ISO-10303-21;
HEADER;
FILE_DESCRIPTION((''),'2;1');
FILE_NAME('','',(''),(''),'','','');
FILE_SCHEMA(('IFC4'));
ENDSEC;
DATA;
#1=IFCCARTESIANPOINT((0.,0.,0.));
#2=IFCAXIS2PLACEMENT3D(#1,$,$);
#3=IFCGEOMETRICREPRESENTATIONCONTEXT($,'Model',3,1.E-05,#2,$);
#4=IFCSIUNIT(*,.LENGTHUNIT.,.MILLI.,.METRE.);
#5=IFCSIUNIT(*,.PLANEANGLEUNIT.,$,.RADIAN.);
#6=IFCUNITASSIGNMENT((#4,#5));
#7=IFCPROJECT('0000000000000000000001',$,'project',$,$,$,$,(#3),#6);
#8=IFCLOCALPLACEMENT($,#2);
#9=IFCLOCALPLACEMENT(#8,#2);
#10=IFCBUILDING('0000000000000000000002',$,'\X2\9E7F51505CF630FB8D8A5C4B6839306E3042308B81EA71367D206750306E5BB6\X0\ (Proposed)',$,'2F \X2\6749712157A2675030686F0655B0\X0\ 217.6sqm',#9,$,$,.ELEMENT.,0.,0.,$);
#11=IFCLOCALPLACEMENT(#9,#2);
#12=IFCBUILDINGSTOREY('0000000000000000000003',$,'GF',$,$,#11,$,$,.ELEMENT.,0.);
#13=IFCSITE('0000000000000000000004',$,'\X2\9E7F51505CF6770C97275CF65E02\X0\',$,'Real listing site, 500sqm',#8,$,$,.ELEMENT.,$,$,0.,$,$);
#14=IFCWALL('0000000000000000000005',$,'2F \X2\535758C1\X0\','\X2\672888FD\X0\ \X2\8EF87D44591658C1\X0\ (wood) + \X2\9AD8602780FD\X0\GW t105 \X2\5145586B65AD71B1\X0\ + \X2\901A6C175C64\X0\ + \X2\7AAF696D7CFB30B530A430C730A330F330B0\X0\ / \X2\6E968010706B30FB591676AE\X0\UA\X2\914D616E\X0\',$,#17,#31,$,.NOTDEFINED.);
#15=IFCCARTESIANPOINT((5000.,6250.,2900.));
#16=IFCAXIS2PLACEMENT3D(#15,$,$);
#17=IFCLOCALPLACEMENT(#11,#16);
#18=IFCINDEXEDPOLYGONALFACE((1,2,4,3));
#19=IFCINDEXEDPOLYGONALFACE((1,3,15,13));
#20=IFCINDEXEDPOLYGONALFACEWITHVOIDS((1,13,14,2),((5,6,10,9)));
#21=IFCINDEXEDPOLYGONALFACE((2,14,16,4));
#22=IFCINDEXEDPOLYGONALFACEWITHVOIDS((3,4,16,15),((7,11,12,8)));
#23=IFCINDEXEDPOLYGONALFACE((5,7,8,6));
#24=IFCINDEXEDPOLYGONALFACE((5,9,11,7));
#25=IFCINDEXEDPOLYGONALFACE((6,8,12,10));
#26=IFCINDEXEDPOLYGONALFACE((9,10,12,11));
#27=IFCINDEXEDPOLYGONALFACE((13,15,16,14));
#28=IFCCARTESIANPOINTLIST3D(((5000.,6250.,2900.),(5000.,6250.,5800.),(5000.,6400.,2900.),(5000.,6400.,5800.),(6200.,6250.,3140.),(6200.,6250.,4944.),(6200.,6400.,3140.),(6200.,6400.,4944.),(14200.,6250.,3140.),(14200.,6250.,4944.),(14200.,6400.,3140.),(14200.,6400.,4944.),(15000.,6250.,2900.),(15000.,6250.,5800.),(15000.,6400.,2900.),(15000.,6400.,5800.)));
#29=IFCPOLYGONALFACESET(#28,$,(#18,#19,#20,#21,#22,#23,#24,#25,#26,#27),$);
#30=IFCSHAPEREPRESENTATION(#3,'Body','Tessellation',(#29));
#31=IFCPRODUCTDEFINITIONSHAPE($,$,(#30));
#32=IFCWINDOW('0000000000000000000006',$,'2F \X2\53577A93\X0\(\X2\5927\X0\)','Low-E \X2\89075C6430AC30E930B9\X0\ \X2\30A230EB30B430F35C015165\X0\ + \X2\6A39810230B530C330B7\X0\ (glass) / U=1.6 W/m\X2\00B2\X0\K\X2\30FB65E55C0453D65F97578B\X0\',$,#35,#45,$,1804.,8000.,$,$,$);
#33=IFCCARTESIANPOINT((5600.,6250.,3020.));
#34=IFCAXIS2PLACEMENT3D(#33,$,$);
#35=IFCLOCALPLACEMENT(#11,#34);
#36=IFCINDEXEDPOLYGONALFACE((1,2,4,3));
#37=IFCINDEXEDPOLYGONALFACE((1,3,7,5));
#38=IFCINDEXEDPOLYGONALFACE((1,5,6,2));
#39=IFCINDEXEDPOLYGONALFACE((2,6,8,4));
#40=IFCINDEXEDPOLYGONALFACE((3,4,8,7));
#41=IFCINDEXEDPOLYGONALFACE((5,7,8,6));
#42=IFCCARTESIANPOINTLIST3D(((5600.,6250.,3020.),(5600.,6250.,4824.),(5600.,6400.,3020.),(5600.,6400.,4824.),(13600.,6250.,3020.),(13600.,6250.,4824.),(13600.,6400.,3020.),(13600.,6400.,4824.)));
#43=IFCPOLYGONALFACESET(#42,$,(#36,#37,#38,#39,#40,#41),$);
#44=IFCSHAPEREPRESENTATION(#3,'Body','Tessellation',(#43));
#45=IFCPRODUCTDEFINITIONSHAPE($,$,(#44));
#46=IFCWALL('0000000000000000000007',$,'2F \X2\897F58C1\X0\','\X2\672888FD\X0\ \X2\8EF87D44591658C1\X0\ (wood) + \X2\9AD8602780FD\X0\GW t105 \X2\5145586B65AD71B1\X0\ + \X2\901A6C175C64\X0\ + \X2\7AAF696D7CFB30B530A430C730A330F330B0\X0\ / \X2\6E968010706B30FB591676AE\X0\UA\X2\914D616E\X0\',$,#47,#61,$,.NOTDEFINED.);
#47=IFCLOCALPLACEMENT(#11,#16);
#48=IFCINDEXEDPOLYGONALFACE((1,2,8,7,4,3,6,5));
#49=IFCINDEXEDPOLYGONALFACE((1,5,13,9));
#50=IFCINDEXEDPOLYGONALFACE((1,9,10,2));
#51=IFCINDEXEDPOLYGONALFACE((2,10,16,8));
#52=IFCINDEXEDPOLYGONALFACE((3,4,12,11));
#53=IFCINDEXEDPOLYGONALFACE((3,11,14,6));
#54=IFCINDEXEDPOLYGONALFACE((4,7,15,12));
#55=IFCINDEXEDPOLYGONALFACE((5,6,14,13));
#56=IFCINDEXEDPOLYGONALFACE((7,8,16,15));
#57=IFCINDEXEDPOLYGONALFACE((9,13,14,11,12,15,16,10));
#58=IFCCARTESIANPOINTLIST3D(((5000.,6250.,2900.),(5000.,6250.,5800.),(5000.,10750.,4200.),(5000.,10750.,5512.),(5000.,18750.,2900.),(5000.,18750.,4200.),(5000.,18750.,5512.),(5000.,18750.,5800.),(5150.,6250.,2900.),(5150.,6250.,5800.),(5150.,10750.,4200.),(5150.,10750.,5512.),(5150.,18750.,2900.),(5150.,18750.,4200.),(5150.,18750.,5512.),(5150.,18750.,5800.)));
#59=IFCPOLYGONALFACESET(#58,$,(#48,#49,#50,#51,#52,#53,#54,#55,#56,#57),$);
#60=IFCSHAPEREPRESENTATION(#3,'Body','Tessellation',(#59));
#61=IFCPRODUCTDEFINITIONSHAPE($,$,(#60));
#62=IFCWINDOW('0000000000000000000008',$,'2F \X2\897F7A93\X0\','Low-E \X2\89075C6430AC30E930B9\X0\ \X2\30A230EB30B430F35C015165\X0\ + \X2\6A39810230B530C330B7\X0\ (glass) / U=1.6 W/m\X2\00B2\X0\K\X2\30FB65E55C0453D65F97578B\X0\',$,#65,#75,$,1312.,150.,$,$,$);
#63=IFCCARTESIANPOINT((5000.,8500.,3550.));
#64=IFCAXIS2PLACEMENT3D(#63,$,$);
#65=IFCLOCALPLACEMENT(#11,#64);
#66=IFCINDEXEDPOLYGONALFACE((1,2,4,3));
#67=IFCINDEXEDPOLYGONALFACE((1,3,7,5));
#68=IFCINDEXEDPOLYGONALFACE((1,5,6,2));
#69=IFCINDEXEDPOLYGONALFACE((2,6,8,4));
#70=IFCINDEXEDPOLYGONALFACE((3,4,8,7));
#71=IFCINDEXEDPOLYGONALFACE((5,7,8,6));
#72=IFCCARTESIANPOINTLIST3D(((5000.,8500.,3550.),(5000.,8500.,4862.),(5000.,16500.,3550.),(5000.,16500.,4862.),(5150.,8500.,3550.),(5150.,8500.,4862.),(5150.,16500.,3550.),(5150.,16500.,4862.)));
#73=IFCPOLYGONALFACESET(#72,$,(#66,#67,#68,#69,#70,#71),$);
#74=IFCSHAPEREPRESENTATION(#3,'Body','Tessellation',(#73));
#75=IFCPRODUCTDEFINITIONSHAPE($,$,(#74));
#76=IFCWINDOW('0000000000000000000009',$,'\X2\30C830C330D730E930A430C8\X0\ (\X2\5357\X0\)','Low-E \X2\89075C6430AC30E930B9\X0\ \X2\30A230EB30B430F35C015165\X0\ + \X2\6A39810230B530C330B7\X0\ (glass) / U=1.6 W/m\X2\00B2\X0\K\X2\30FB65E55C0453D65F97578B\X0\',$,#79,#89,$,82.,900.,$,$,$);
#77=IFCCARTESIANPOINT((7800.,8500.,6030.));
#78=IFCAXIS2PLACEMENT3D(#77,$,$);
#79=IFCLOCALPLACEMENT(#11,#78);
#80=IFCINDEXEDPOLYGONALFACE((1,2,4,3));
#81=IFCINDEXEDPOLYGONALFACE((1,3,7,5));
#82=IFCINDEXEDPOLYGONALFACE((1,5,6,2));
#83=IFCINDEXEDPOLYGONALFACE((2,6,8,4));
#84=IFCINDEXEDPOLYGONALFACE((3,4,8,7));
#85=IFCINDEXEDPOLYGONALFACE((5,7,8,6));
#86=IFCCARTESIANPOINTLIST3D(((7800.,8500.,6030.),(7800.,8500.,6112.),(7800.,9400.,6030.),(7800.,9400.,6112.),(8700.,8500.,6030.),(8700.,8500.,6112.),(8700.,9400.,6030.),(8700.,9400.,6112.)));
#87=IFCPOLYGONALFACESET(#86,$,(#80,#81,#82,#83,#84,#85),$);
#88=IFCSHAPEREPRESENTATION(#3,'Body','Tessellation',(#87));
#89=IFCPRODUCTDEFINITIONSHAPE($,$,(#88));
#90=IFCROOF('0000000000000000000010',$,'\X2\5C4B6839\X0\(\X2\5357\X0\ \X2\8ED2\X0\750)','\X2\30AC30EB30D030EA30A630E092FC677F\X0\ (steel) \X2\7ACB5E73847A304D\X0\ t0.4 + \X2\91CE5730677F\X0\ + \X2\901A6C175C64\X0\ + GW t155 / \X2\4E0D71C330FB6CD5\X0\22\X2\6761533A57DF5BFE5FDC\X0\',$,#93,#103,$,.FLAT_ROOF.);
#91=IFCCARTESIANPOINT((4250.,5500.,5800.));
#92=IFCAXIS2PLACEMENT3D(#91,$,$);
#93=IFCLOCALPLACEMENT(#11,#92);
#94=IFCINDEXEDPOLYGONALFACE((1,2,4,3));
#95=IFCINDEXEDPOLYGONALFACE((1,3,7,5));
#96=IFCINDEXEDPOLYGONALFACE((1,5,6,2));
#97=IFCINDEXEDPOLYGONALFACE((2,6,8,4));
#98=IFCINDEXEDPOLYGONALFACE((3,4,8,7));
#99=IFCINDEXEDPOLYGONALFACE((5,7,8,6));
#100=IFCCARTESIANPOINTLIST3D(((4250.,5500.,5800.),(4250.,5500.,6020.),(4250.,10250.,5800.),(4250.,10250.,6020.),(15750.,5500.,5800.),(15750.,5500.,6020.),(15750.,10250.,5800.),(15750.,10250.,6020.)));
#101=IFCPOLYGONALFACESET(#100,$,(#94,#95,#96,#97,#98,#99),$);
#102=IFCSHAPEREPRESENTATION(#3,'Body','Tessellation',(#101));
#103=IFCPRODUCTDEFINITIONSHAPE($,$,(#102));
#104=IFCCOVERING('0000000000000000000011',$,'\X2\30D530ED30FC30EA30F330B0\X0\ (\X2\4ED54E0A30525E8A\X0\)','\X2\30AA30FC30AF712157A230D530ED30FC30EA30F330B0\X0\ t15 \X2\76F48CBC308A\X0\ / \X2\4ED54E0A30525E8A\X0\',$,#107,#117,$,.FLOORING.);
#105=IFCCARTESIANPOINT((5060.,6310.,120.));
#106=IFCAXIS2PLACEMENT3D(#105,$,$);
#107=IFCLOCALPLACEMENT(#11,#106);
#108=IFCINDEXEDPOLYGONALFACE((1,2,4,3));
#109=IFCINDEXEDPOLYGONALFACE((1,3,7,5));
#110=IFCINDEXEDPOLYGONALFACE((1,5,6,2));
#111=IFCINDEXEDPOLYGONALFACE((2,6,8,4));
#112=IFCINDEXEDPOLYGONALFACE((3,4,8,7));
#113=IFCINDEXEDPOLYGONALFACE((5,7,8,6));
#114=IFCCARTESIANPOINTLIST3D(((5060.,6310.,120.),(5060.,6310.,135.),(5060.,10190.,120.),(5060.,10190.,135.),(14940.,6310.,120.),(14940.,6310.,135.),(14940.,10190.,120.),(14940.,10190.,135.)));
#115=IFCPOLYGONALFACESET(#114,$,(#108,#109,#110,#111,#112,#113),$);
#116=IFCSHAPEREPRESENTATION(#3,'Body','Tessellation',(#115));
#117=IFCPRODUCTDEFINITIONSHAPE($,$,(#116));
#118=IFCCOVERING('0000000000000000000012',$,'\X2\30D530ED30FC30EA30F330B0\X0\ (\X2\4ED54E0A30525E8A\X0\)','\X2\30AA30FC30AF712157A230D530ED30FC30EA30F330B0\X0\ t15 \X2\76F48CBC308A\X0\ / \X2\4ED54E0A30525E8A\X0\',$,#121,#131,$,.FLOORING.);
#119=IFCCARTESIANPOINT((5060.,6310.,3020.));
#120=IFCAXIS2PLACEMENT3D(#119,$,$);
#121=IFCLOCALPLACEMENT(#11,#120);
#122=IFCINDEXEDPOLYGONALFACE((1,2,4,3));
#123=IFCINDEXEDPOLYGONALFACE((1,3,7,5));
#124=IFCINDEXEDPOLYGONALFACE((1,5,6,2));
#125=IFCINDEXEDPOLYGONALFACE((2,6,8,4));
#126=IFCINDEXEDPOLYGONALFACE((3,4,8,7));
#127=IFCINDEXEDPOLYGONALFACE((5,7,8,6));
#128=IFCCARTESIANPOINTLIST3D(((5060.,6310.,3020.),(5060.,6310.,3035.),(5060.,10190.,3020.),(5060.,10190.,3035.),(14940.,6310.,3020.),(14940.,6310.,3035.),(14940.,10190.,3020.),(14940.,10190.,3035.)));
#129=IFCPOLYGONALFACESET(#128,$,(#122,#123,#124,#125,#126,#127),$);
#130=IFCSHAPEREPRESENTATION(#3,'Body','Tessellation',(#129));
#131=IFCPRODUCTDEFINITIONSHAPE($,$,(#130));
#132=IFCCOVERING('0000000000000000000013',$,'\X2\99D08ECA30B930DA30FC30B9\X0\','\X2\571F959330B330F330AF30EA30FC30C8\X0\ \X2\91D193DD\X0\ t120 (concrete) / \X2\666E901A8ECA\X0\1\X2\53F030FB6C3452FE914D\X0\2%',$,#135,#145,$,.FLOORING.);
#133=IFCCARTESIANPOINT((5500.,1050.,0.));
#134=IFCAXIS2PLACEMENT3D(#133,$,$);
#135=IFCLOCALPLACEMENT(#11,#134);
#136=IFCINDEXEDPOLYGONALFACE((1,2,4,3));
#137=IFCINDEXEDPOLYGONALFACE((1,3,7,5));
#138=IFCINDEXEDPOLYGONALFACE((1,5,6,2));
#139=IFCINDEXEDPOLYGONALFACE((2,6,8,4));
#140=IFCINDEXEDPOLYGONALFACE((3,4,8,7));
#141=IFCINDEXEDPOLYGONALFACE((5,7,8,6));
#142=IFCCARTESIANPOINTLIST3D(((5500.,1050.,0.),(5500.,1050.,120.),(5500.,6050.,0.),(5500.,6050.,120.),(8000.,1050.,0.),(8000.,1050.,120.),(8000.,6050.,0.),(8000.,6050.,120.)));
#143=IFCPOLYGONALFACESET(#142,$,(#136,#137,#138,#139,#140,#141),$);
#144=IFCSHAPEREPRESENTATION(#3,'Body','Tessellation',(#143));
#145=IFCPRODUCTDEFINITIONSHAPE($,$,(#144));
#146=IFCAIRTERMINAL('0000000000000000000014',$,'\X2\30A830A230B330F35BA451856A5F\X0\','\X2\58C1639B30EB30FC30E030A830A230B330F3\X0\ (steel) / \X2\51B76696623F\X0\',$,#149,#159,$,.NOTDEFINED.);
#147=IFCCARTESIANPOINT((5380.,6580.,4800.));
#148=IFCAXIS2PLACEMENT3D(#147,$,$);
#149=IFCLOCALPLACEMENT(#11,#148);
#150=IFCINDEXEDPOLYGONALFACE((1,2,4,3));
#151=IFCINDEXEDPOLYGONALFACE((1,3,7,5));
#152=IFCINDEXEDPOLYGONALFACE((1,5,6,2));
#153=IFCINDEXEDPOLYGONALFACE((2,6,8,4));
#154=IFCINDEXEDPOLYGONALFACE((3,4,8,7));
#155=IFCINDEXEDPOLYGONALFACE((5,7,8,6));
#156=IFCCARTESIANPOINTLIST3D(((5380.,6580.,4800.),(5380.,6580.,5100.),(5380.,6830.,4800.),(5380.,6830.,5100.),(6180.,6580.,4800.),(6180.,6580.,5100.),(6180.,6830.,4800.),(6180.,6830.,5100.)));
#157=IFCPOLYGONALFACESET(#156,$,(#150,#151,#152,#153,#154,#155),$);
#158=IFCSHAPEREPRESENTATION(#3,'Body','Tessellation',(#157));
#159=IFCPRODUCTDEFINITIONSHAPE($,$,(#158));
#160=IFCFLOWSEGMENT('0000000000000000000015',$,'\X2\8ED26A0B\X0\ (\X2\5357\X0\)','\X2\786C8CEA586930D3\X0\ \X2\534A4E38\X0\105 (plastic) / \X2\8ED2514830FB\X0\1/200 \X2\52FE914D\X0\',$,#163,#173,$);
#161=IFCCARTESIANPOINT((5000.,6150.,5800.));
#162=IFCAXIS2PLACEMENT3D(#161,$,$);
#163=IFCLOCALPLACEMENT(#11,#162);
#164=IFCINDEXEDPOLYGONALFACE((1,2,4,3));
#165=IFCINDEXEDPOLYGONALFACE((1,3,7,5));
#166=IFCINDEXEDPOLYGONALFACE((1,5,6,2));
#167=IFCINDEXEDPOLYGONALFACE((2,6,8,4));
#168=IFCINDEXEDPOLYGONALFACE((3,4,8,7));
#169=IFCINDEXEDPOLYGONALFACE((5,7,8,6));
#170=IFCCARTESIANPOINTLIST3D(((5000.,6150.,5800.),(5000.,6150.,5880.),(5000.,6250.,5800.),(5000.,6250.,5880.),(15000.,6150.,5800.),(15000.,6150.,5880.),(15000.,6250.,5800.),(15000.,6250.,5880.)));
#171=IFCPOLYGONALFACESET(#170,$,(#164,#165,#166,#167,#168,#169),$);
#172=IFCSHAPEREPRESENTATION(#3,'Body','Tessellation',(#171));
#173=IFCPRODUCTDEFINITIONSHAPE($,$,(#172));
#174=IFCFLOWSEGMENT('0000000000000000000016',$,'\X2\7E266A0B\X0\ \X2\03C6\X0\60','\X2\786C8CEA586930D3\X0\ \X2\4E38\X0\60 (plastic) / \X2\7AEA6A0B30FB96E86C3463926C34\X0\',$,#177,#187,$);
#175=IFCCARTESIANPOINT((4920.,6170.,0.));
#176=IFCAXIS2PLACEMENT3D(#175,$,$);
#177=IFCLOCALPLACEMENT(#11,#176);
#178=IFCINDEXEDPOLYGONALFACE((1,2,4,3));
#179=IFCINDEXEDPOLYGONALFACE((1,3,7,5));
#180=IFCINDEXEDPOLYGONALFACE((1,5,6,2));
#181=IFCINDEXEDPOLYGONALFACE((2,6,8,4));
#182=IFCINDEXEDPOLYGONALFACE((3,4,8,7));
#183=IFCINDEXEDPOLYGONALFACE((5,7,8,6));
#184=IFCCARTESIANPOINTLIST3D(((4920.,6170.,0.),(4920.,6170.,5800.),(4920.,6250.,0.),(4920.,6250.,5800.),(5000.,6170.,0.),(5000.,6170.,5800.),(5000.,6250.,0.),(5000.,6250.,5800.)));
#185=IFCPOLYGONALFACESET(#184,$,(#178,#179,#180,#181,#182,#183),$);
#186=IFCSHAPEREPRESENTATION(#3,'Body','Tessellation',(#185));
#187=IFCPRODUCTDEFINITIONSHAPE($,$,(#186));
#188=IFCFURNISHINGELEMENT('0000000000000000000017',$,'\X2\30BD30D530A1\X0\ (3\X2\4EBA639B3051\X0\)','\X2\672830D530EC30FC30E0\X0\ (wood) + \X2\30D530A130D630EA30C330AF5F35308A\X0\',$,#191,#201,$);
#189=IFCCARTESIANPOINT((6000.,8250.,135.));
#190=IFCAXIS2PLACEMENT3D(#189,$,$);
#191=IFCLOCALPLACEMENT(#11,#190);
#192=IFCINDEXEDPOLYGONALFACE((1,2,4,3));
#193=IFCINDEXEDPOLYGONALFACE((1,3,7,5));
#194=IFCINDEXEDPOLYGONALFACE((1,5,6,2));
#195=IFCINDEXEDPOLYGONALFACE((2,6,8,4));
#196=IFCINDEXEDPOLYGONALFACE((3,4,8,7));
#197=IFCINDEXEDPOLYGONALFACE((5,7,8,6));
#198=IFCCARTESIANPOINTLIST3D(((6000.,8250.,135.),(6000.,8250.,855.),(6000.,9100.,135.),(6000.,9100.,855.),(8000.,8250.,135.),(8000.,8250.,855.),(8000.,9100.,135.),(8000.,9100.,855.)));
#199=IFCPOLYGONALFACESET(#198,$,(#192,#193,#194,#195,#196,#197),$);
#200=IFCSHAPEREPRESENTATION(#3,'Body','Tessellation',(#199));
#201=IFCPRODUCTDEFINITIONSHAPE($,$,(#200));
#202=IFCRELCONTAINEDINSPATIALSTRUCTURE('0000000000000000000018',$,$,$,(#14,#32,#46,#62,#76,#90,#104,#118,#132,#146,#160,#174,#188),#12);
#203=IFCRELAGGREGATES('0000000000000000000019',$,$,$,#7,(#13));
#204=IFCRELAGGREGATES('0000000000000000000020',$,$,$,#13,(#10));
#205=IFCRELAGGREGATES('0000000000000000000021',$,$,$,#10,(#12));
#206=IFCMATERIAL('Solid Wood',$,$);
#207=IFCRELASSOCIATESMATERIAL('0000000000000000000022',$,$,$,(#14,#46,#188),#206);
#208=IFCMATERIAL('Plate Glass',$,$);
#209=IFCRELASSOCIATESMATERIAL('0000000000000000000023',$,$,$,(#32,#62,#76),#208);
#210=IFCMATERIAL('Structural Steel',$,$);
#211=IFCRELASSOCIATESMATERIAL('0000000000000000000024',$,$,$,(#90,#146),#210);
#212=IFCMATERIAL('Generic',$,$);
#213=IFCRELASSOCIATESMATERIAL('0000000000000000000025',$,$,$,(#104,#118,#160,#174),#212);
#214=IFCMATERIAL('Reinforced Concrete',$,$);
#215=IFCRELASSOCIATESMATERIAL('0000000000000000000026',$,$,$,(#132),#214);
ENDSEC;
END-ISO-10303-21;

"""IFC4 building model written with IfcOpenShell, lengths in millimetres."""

from ifc_helpers import new_model, si_unit, frame, frame_2d, origin, place, context, project, spatial, rectangle, extrude, material, element, fill, save


model = new_model("IFC4")

# Units and contexts
model_context = context("Model", 3, precision=1e-05, world=origin())
ifc_project = project(units=[si_unit("LENGTHUNIT", "METRE", prefix="MILLI"), si_unit("PLANEANGLEUNIT", "RADIAN")], contexts=[model_context])

# Site, building, storey
site_placement = place(None, origin())
site = spatial("IfcSite", under=ifc_project, at=site_placement, Name="鹿児島県霧島市", ObjectType="Real listing site, 500sqm", CompositionType="ELEMENT", RefElevation=0.0)
building_placement = place(site_placement, origin())
building = spatial("IfcBuilding", under=site, at=building_placement, Name="鹿児島・越屋根のある自然素材の家 (Proposed)", ObjectType="2F 杉無垢材と漆喰 217.6sqm", CompositionType="ELEMENT", ElevationOfRefHeight=0.0, ElevationOfTerrain=0.0)
storey_placement = place(building_placement, origin())
storey = spatial("IfcBuildingStorey", under=building, at=storey_placement, Name="GF", CompositionType="ELEMENT", Elevation=0.0)

# Shared definitions
ifc_material_1 = material(Name="Solid Wood")

# Shared definitions
ifc_material_2 = material(Name="Reinforced Concrete")

# Shared definitions
ifc_material_3 = material(Name="Plate Glass")

# Walls, openings, windows
wall_1_placement = place(storey_placement, frame((5000.0, 6250.0, 2900.0)))
wall_1 = element("IfcWall", 1, at=wall_1_placement, inside=storey, material=ifc_material_1, Name="2F 南壁", Description="木製 軸組外壁 (wood) + 高性能GW t105 充填断熱 + 通気層 + 窯業系サイディング / 準耐火・外皮UA配慮", PredefinedType="NOTDEFINED", context=model_context, shape_type="SweptSolid", body=[
    extrude(rectangle(XDim=10000.0, YDim=150.0, at=frame_2d((5000.0, 75.0))), frame((5000.0, 6250.0, 2900.0)), (0.0, 0.0, 1.0), 2900.0),
])
opening_1_placement = place(storey_placement, frame((5600.0, 6250.0, 3020.0)))
opening_1 = element("IfcOpeningElement", 2, at=opening_1_placement, cuts=wall_1, PredefinedType="NOTDEFINED", context=model_context, shape_type="SweptSolid", body=[
    extrude(rectangle(XDim=8000.0, YDim=150.0, at=frame_2d((4000.0, 75.0))), frame((5600.0, 6250.0, 3020.0)), (0.0, 0.0, 1.0), 1804.0),
])
window_1_placement = place(storey_placement, frame((5600.0, 6250.0, 3020.0)))
window_1 = element("IfcWindow", 3, at=window_1_placement, inside=storey, material=ifc_material_3, Name="2F 南窓(大)", Description="Low-E 複層ガラス アルゴン封入 + 樹脂サッシ (glass) / U=1.6 W/m²K・日射取得型", OverallHeight=1804.0, OverallWidth=8000.0, context=model_context, shape_type="SweptSolid", body=[
    extrude(rectangle(XDim=8000.0, YDim=150.0, at=frame_2d((4000.0, 75.0))), frame((5600.0, 6250.0, 3020.0)), (0.0, 0.0, 1.0), 1804.0),
])
fill(opening_1, window_1)
wall_2_placement = place(storey_placement, frame((5000.0, 6250.0, 2900.0)))
wall_2 = element("IfcWall", 4, at=wall_2_placement, inside=storey, material=ifc_material_1, Name="2F 西壁", Description="木製 軸組外壁 (wood) + 高性能GW t105 充填断熱 + 通気層 + 窯業系サイディング / 準耐火・外皮UA配慮", PredefinedType="NOTDEFINED", context=model_context, shape_type="SweptSolid", body=[
    extrude(rectangle(XDim=150.0, YDim=12500.0, at=frame_2d((75.0, 6250.0))), frame((5000.0, 6250.0, 2900.0)), (0.0, 0.0, 1.0), 2900.0),
])
opening_2_placement = place(storey_placement, frame((5000.0, 8500.0, 3550.0)))
opening_2 = element("IfcOpeningElement", 5, at=opening_2_placement, cuts=wall_2, PredefinedType="NOTDEFINED", context=model_context, shape_type="SweptSolid", body=[
    extrude(rectangle(XDim=150.0, YDim=8000.0, at=frame_2d((75.0, 4000.0))), frame((5000.0, 8500.0, 3550.0)), (0.0, 0.0, 1.0), 1312.0),
])
window_2_placement = place(storey_placement, frame((5000.0, 8500.0, 3550.0)))
window_2 = element("IfcWindow", 6, at=window_2_placement, inside=storey, material=ifc_material_3, Name="2F 西窓", Description="Low-E 複層ガラス アルゴン封入 + 樹脂サッシ (glass) / U=1.6 W/m²K・日射取得型", OverallHeight=1312.0, OverallWidth=150.0, context=model_context, shape_type="SweptSolid", body=[
    extrude(rectangle(XDim=150.0, YDim=8000.0, at=frame_2d((75.0, 4000.0))), frame((5000.0, 8500.0, 3550.0)), (0.0, 0.0, 1.0), 1312.0),
])
fill(opening_2, window_2)

# Window
window_3_placement = place(storey_placement, frame((7800.0, 8500.0, 6030.0)))
element("IfcWindow", 7, at=window_3_placement, inside=storey, material=ifc_material_3, Name="トップライト (南)", Description="Low-E 複層ガラス アルゴン封入 + 樹脂サッシ (glass) / U=1.6 W/m²K・日射取得型", OverallHeight=82.0, OverallWidth=900.0, context=model_context, shape_type="SweptSolid", body=[
    extrude(rectangle(XDim=900.0, YDim=900.0, at=frame_2d((450.0, 450.0))), frame((7800.0, 8500.0, 6030.0)), (0.0, 0.0, 1.0), 82.0),
])

# Roof
ifc_material_4 = material(Name="Structural Steel")
for number, where, name in (
    (8, (4250.0, 5500.0, 5800.0), "屋根(南 軒750)"),
):
    element("IfcRoof", number, at=place(storey_placement, frame(where)), inside=storey, material=ifc_material_4, Name=name, Description="ガルバリウム鋼板 (steel) 立平葺き t0.4 + 野地板 + 通気層 + GW t155 / 不燃・法22条区域対応", PredefinedType="FLAT_ROOF", context=model_context, shape_type="SweptSolid", body=[
        extrude(rectangle(XDim=11500.0, YDim=4750.0, at=frame_2d((5750.0, 2375.0))), frame((4250.0, 5500.0, 5800.0)), (0.0, 0.0, 1.0), 220.0),
    ])

# Coverings
ifc_material_5 = material(Name="Generic")
covering_1_placement = place(storey_placement, frame((5060.0, 6310.0, 120.0)))
element("IfcCovering", 9, at=covering_1_placement, inside=storey, material=ifc_material_5, Name="フローリング (仕上げ床)", Description="オーク無垢フローリング t15 直貼り / 仕上げ床", PredefinedType="FLOORING", context=model_context, shape_type="SweptSolid", body=[
    extrude(rectangle(XDim=9880.0, YDim=3880.0, at=frame_2d((4940.0, 1940.0))), frame((5060.0, 6310.0, 120.0)), (0.0, 0.0, 1.0), 15.0),
])
covering_2_placement = place(storey_placement, frame((5060.0, 6310.0, 3020.0)))
element("IfcCovering", 10, at=covering_2_placement, inside=storey, material=ifc_material_5, Name="フローリング (仕上げ床)", Description="オーク無垢フローリング t15 直貼り / 仕上げ床", PredefinedType="FLOORING", context=model_context, shape_type="SweptSolid", body=[
    extrude(rectangle(XDim=9880.0, YDim=3880.0, at=frame_2d((4940.0, 1940.0))), frame((5060.0, 6310.0, 3020.0)), (0.0, 0.0, 1.0), 15.0),
])
covering_3_placement = place(storey_placement, frame((5500.0, 1050.0, 0.0)))
element("IfcCovering", 11, at=covering_3_placement, inside=storey, material=ifc_material_2, Name="駐車スペース", Description="土間コンクリート 金鏝 t120 (concrete) / 普通車1台・水勾配2%", PredefinedType="FLOORING", context=model_context, shape_type="SweptSolid", body=[
    extrude(rectangle(XDim=2500.0, YDim=5000.0, at=frame_2d((1250.0, 2500.0))), frame((5500.0, 1050.0, 0.0)), (0.0, 0.0, 1.0), 120.0),
])

# Air terminal
air_terminal_placement = place(storey_placement, frame((5380.0, 6580.0, 4800.0)))
element("IfcAirTerminal", 12, at=air_terminal_placement, inside=storey, material=ifc_material_4, Name="エアコン室内機", Description="壁掛ルームエアコン (steel) / 冷暖房", PredefinedType="NOTDEFINED", context=model_context, shape_type="SweptSolid", body=[
    extrude(rectangle(XDim=800.0, YDim=250.0, at=frame_2d((400.0, 125.0))), frame((5380.0, 6580.0, 4800.0)), (0.0, 0.0, 1.0), 300.0),
])

# Flow segments
flow_segment_1_placement = place(storey_placement, frame((5000.0, 6150.0, 5800.0)))
element("IfcFlowSegment", 13, at=flow_segment_1_placement, inside=storey, material=ifc_material_5, Name="軒樋 (南)", Description="硬質塩ビ 半丸105 (plastic) / 軒先・1/200 勾配", context=model_context, shape_type="SweptSolid", body=[
    extrude(rectangle(XDim=10000.0, YDim=100.0, at=frame_2d((5000.0, 50.0))), frame((5000.0, 6150.0, 5800.0)), (0.0, 0.0, 1.0), 80.0),
])
flow_segment_2_placement = place(storey_placement, frame((4920.0, 6170.0, 0.0)))
element("IfcFlowSegment", 14, at=flow_segment_2_placement, inside=storey, material=ifc_material_5, Name="縦樋 φ60", Description="硬質塩ビ 丸60 (plastic) / 竪樋・雨水排水", context=model_context, shape_type="SweptSolid", body=[
    extrude(rectangle(XDim=80.0, YDim=80.0, at=frame_2d((40.0, 40.0))), frame((4920.0, 6170.0, 0.0)), (0.0, 0.0, 1.0), 5800.0),
])

# Furnishing element
furnishing_1_placement = place(storey_placement, frame((6000.0, 8250.0, 135.0)))
element("IfcFurnishingElement", 15, at=furnishing_1_placement, inside=storey, material=ifc_material_1, Name="ソファ (3人掛け)", Description="木フレーム (wood) + ファブリック張り", context=model_context, shape_type="SweptSolid", body=[
    extrude(rectangle(XDim=2000.0, YDim=850.0, at=frame_2d((1000.0, 425.0))), frame((6000.0, 8250.0, 135.0)), (0.0, 0.0, 1.0), 720.0),
])

save(model, "model.ifc")
